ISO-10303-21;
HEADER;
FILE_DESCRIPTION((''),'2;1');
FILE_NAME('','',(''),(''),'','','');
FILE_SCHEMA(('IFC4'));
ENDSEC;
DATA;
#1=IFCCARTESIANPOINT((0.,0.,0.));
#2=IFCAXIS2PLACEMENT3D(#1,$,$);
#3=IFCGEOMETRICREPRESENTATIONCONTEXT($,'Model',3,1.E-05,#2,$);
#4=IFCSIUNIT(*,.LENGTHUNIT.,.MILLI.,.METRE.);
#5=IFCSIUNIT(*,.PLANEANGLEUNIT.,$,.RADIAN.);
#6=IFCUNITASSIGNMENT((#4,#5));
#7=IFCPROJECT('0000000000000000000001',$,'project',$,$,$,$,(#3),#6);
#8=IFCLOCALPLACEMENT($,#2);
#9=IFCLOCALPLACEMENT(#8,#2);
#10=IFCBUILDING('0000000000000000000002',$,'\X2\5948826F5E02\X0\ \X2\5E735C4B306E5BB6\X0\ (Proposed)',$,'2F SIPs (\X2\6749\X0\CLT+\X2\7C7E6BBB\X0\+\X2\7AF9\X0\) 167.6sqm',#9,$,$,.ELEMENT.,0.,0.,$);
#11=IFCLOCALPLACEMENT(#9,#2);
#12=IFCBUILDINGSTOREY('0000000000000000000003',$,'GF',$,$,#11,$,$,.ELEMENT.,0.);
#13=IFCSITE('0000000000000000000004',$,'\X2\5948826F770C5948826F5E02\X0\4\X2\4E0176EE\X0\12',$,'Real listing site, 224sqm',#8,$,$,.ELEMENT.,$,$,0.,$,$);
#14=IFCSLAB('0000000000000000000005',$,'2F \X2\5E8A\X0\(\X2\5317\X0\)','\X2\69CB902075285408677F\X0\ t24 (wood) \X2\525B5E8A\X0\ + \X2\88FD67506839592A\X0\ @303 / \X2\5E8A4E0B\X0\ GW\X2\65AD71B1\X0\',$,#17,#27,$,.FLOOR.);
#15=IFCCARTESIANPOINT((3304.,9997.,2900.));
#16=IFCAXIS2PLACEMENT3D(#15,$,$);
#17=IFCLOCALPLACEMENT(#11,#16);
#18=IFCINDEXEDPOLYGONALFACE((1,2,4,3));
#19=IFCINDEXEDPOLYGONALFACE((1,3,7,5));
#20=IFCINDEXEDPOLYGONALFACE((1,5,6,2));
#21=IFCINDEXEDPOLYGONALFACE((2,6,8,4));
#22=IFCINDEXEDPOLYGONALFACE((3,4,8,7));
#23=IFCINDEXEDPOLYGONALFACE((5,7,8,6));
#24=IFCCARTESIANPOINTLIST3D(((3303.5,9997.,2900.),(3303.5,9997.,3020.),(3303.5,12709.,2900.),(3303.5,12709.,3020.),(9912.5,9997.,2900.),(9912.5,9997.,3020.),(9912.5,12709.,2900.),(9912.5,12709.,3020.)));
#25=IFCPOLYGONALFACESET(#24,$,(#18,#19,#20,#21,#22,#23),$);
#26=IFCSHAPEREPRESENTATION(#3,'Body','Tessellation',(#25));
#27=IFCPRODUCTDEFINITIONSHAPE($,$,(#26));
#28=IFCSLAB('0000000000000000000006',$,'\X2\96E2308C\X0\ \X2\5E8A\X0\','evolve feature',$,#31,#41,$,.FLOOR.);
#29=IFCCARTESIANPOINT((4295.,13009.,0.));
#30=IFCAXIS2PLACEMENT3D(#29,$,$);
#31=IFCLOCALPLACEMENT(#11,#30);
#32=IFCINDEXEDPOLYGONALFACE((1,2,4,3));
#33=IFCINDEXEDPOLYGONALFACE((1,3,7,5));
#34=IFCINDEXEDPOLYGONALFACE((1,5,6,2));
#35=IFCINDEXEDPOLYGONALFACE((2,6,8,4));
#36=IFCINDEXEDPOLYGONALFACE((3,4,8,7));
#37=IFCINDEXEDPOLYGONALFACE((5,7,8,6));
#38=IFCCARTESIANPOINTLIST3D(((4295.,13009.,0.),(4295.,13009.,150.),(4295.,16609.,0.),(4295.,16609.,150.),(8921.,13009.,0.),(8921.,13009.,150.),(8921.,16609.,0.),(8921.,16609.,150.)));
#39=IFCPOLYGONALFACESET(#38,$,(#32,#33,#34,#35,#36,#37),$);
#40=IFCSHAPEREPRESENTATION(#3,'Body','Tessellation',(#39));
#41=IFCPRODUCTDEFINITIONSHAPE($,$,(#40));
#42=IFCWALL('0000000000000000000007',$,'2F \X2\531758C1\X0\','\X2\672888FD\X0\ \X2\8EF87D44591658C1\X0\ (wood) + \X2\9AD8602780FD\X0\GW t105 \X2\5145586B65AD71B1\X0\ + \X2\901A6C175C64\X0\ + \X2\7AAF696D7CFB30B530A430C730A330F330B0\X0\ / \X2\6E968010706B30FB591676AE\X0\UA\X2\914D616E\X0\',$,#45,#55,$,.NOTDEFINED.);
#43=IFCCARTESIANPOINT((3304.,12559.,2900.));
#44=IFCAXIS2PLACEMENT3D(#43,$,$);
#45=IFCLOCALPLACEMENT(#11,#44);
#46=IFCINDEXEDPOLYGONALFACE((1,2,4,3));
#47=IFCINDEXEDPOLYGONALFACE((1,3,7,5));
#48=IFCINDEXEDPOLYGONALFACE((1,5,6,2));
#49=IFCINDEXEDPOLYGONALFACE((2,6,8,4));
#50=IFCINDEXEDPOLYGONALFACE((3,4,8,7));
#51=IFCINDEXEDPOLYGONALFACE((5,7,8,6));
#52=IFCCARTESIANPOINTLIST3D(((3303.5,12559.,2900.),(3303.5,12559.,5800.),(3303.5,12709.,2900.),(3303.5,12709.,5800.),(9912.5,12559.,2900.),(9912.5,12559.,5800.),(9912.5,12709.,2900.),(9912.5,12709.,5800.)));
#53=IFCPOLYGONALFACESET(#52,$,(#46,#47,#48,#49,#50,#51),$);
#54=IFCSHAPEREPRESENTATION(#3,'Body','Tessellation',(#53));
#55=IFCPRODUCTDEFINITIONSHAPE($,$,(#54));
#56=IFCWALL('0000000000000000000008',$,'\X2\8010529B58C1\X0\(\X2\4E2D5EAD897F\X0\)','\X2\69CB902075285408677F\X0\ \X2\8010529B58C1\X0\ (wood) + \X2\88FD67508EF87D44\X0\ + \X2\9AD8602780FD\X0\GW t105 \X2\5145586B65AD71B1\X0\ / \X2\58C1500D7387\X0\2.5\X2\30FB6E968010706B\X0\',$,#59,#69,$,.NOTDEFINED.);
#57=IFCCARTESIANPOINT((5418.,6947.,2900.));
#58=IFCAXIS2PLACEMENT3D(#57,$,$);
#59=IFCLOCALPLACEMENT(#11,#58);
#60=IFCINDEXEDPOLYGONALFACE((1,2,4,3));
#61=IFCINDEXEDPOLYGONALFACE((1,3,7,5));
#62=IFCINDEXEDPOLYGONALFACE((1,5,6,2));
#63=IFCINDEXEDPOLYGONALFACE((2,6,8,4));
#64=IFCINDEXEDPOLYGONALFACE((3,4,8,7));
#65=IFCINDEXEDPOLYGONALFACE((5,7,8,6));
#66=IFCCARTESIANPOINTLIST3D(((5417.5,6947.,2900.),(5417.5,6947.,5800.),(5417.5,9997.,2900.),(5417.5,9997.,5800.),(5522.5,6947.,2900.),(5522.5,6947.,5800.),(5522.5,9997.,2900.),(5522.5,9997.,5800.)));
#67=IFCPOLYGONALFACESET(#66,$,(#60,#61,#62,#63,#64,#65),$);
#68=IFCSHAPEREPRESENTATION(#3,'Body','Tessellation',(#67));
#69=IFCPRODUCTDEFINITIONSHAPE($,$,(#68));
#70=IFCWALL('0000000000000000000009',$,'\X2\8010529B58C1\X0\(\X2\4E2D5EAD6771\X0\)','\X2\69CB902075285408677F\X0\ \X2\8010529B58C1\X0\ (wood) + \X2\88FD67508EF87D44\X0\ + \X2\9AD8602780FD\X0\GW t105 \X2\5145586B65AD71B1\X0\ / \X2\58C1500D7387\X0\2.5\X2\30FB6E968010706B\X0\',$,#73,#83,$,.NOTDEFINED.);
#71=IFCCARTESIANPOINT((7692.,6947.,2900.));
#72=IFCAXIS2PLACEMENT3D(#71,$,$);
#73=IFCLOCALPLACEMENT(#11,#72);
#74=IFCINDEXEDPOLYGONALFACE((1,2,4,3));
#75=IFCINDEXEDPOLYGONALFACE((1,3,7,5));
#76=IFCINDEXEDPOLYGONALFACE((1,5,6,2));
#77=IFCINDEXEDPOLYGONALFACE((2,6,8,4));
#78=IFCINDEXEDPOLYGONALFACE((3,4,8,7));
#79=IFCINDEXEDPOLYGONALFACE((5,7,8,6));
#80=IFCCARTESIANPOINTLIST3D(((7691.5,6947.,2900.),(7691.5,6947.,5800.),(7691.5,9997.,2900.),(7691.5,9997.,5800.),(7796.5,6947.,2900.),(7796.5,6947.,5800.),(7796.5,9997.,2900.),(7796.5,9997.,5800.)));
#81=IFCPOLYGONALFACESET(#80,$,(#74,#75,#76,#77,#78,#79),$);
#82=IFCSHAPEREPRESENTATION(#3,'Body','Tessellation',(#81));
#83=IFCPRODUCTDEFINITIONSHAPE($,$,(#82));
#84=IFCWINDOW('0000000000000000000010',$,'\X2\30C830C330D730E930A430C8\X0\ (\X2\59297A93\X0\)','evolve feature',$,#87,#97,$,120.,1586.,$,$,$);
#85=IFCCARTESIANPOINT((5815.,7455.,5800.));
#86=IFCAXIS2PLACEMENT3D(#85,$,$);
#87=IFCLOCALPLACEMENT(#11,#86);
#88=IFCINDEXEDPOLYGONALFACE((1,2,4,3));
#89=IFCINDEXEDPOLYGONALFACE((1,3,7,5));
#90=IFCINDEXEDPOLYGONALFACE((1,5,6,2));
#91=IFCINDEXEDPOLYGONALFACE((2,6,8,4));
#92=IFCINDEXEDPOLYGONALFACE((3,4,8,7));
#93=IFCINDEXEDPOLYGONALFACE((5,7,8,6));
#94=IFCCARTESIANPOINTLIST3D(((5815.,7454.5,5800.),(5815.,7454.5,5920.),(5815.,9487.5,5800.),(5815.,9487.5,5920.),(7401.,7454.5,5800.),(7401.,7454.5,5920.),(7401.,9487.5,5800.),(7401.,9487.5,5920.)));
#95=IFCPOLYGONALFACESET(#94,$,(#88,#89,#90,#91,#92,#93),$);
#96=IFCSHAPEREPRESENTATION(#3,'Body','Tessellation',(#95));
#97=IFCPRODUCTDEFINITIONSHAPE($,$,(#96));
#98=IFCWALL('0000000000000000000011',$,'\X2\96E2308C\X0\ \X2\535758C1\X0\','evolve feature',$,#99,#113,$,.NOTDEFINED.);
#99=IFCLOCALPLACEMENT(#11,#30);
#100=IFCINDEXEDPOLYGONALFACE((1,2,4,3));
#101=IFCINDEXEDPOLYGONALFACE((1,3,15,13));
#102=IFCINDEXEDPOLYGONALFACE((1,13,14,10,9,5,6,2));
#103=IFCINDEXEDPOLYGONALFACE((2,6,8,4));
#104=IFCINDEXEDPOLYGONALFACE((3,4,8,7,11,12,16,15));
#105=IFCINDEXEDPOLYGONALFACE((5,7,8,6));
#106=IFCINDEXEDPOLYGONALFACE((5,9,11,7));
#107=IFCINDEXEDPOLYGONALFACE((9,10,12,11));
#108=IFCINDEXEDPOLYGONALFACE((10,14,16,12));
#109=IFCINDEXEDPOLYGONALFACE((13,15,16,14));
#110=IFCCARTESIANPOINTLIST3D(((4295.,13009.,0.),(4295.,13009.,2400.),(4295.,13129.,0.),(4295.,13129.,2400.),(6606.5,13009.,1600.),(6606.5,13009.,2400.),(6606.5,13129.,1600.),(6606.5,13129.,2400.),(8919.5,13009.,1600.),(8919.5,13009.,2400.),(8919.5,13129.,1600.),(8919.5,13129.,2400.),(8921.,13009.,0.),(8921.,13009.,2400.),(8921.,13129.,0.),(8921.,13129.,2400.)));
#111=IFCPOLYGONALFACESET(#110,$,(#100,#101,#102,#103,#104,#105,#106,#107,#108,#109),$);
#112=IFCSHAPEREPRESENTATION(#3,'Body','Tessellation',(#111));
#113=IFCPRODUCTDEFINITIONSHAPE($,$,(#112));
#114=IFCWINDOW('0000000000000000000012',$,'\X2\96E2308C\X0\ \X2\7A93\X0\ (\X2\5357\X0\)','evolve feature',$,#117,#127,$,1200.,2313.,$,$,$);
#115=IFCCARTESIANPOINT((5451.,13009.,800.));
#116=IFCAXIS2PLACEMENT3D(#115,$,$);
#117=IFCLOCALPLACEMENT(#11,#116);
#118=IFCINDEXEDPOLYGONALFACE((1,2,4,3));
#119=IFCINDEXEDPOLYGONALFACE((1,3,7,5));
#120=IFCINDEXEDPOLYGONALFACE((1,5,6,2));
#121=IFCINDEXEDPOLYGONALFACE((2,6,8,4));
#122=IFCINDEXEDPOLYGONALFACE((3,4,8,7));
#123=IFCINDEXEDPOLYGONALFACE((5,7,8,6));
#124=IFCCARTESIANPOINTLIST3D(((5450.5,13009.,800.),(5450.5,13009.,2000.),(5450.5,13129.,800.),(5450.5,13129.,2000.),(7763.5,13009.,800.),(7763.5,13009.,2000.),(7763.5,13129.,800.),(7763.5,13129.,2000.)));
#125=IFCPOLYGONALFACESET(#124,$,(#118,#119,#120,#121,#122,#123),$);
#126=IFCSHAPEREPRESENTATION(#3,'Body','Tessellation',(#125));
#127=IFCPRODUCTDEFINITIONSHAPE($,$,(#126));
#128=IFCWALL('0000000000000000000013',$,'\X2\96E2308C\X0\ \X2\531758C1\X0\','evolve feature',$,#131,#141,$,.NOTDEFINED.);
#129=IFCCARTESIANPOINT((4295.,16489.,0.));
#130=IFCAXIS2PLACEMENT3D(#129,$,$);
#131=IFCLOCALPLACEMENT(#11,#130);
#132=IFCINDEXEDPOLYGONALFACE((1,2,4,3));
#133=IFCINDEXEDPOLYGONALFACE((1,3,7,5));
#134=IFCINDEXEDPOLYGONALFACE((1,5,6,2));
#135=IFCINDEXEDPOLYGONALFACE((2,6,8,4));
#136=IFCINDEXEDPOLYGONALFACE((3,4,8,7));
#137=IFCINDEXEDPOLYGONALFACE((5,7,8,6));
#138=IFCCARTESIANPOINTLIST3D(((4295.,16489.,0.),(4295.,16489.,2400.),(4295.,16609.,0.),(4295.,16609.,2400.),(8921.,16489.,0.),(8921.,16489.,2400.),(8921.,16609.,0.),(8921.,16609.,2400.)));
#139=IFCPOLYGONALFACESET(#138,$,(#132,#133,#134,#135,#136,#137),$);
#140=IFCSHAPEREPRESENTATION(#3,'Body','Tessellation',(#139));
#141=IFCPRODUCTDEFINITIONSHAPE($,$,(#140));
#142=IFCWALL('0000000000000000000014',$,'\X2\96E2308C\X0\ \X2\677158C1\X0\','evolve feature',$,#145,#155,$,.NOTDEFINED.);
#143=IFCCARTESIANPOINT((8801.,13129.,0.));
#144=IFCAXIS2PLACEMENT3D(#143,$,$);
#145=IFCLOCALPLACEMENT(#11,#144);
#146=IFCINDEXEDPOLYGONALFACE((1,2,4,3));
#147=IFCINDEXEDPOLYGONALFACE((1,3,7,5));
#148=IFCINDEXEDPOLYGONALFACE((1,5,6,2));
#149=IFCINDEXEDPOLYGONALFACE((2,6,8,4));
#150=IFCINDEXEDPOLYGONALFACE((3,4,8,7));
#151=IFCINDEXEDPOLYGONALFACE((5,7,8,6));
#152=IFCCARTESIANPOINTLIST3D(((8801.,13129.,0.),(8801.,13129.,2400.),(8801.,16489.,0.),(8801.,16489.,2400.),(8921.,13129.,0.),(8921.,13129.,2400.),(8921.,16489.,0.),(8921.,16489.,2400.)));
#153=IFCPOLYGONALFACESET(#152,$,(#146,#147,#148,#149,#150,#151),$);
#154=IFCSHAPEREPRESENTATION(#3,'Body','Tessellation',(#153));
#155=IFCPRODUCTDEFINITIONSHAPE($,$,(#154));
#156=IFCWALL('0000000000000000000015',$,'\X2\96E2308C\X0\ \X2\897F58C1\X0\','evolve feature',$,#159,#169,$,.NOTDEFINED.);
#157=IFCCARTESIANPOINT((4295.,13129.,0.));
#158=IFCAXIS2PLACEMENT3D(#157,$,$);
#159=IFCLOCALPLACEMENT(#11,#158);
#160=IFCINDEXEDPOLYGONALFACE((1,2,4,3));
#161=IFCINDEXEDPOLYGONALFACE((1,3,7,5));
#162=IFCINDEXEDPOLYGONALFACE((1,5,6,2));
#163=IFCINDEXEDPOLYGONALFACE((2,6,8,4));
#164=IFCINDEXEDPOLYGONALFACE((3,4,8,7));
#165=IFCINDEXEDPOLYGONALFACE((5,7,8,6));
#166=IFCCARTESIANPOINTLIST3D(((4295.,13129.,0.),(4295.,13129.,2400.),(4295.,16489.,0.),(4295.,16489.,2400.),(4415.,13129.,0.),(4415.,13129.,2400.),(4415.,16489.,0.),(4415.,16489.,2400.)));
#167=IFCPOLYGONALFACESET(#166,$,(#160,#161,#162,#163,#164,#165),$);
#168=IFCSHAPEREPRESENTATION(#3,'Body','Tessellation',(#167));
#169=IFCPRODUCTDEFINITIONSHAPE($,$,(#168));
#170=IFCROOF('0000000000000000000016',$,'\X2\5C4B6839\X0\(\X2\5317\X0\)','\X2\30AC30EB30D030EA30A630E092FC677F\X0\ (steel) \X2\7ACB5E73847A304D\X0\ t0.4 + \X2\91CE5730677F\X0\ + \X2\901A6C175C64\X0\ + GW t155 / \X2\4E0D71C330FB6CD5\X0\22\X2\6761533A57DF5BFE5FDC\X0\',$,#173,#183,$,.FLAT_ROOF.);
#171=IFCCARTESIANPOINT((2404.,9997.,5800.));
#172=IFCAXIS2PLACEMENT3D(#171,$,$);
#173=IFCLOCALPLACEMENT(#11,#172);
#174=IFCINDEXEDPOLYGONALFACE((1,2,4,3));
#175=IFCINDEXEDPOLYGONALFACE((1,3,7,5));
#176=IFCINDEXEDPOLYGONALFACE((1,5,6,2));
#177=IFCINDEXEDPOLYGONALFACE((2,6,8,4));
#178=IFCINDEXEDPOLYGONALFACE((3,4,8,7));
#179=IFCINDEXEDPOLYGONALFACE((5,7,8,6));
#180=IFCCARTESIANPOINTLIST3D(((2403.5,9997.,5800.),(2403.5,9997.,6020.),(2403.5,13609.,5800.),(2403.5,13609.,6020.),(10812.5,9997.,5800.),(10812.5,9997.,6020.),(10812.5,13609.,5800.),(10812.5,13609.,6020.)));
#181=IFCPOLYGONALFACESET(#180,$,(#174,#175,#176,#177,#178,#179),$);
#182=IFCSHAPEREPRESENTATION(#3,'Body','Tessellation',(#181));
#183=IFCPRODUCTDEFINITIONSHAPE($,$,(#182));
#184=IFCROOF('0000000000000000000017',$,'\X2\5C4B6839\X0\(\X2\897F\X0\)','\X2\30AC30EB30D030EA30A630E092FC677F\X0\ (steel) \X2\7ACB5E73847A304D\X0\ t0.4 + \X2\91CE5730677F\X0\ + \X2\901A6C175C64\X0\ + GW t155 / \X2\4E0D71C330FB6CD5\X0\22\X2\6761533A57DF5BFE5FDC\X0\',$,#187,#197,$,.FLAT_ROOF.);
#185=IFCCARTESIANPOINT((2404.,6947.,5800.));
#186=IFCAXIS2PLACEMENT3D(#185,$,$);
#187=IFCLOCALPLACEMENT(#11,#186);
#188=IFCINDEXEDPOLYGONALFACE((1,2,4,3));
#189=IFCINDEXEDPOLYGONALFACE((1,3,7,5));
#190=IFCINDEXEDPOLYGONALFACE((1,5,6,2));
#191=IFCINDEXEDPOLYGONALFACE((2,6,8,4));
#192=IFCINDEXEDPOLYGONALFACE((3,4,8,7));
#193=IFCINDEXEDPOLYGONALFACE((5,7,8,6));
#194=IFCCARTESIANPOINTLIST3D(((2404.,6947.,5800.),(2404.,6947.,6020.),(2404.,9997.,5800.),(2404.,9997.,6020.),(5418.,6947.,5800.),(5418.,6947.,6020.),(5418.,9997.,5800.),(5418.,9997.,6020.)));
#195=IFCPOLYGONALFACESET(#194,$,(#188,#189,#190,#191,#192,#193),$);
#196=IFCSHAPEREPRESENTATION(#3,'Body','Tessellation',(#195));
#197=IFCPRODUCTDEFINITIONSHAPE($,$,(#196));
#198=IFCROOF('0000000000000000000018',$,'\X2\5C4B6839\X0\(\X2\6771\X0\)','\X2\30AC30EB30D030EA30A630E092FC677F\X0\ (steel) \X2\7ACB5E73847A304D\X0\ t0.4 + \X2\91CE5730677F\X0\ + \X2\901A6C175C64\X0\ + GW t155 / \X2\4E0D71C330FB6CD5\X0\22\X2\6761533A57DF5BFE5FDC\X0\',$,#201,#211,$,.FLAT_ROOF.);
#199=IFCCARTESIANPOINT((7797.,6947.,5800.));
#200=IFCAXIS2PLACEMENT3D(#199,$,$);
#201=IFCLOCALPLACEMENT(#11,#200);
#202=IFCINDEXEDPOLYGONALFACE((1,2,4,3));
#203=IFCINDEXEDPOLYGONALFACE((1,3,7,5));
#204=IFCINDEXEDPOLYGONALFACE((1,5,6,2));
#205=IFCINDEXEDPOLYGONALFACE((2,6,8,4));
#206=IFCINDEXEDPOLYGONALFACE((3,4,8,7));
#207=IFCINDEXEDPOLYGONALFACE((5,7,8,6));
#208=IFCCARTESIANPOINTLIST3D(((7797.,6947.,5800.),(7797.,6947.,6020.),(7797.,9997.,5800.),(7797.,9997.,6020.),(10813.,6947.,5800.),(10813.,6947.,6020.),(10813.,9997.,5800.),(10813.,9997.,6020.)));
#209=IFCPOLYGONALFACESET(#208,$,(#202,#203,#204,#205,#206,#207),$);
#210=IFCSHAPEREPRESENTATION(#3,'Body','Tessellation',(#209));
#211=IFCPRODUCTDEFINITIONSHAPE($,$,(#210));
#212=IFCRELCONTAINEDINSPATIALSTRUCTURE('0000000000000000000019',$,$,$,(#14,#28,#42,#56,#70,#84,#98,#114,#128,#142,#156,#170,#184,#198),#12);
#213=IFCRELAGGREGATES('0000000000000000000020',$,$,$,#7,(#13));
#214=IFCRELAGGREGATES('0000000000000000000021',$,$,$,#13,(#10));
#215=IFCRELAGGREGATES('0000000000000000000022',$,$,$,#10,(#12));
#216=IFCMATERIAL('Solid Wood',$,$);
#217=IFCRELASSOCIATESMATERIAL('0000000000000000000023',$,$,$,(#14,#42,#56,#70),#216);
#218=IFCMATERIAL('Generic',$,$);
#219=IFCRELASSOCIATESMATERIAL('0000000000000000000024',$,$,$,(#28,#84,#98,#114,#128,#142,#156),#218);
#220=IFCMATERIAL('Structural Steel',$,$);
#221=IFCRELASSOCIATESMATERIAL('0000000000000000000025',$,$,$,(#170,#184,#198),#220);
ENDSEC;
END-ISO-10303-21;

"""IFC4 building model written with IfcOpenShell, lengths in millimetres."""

from ifc_helpers import new_model, si_unit, frame, frame_2d, origin, place, context, project, spatial, rectangle, extrude, material, element, fill, save


model = new_model("IFC4")

# Units and contexts
model_context = context("Model", 3, precision=1e-05, world=origin())
ifc_project = project(units=[si_unit("LENGTHUNIT", "METRE", prefix="MILLI"), si_unit("PLANEANGLEUNIT", "RADIAN")], contexts=[model_context])

# Site, building, storey
site_placement = place(None, origin())
site = spatial("IfcSite", under=ifc_project, at=site_placement, Name="奈良県奈良市4丁目12", ObjectType="Real listing site, 224sqm", CompositionType="ELEMENT", RefElevation=0.0)
building_placement = place(site_placement, origin())
building = spatial("IfcBuilding", under=site, at=building_placement, Name="奈良市 平屋の家 (Proposed)", ObjectType="2F SIPs (杉CLT+籾殻+竹) 167.6sqm", CompositionType="ELEMENT", ElevationOfRefHeight=0.0, ElevationOfTerrain=0.0)
storey_placement = place(building_placement, origin())
storey = spatial("IfcBuildingStorey", under=building, at=storey_placement, Name="GF", CompositionType="ELEMENT", Elevation=0.0)

# Slabs
ifc_material_1 = material(Name="Solid Wood")
slab_1_placement = place(storey_placement, frame((3304.0, 9997.0, 2900.0)))
element("IfcSlab", 1, at=slab_1_placement, inside=storey, material=ifc_material_1, Name="2F 床(北)", Description="構造用合板 t24 (wood) 剛床 + 製材根太 @303 / 床下 GW断熱", PredefinedType="FLOOR", context=model_context, shape_type="SweptSolid", body=[
    extrude(rectangle(XDim=6609.0, YDim=2712.0, at=frame_2d((3304.0, 1356.0))), frame((3304.0, 9997.0, 2900.0)), (0.0, 0.0, 1.0), 120.0),
])
ifc_material_2 = material(Name="Generic")
slab_2_placement = place(storey_placement, frame((4295.0, 13009.0, 0.0)))
element("IfcSlab", 2, at=slab_2_placement, inside=storey, material=ifc_material_2, Name="離れ 床", Description="evolve feature", PredefinedType="FLOOR", context=model_context, shape_type="SweptSolid", body=[
    extrude(rectangle(XDim=4626.0, YDim=3600.0, at=frame_2d((2313.0, 1800.0))), frame((4295.0, 13009.0, 0.0)), (0.0, 0.0, 1.0), 150.0),
])

# Wall
wall_1_placement = place(storey_placement, frame((3304.0, 12559.0, 2900.0)))
element("IfcWall", 3, at=wall_1_placement, inside=storey, material=ifc_material_1, Name="2F 北壁", Description="木製 軸組外壁 (wood) + 高性能GW t105 充填断熱 + 通気層 + 窯業系サイディング / 準耐火・外皮UA配慮", PredefinedType="NOTDEFINED", context=model_context, shape_type="SweptSolid", body=[
    extrude(rectangle(XDim=6609.0, YDim=150.0, at=frame_2d((3304.0, 75.0))), frame((3304.0, 12559.0, 2900.0)), (0.0, 0.0, 1.0), 2900.0),
])

# Walls
wall_2_placement = place(storey_placement, frame((5418.0, 6947.0, 2900.0)))
element("IfcWall", 4, at=wall_2_placement, inside=storey, material=ifc_material_1, Name="耐力壁(中庭西)", Description="構造用合板 耐力壁 (wood) + 製材軸組 + 高性能GW t105 充填断熱 / 壁倍率2.5・準耐火", PredefinedType="NOTDEFINED", context=model_context, shape_type="SweptSolid", body=[
    extrude(rectangle(XDim=105.0, YDim=3050.0, at=frame_2d((52.0, 1525.0))), frame((5418.0, 6947.0, 2900.0)), (0.0, 0.0, 1.0), 2900.0),
])
wall_3_placement = place(storey_placement, frame((7692.0, 6947.0, 2900.0)))
element("IfcWall", 5, at=wall_3_placement, inside=storey, material=ifc_material_1, Name="耐力壁(中庭東)", Description="構造用合板 耐力壁 (wood) + 製材軸組 + 高性能GW t105 充填断熱 / 壁倍率2.5・準耐火", PredefinedType="NOTDEFINED", context=model_context, shape_type="SweptSolid", body=[
    extrude(rectangle(XDim=105.0, YDim=3050.0, at=frame_2d((52.0, 1525.0))), frame((7692.0, 6947.0, 2900.0)), (0.0, 0.0, 1.0), 2900.0),
])

# Window
window_1_placement = place(storey_placement, frame((5815.0, 7455.0, 5800.0)))
element("IfcWindow", 6, at=window_1_placement, inside=storey, material=ifc_material_2, Name="トップライト (天窓)", Description="evolve feature", OverallHeight=120.0, OverallWidth=1586.0, context=model_context, shape_type="SweptSolid", body=[
    extrude(rectangle(XDim=1586.0, YDim=2033.0, at=frame_2d((793.0, 1016.0))), frame((5815.0, 7455.0, 5800.0)), (0.0, 0.0, 1.0), 120.0),
])

# Wall, opening, window
wall_4_placement = place(storey_placement, frame((4295.0, 13009.0, 0.0)))
wall_4 = element("IfcWall", 7, at=wall_4_placement, inside=storey, material=ifc_material_2, Name="離れ 南壁", Description="evolve feature", PredefinedType="NOTDEFINED", context=model_context, shape_type="SweptSolid", body=[
    extrude(rectangle(XDim=4626.0, YDim=120.0, at=frame_2d((2313.0, 60.0))), frame((4295.0, 13009.0, 0.0)), (0.0, 0.0, 1.0), 2400.0),
])
opening_1_placement = place(storey_placement, frame((5451.0, 13009.0, 800.0)))
opening_1 = element("IfcOpeningElement", 8, at=opening_1_placement, cuts=wall_4, PredefinedType="NOTDEFINED", context=model_context, shape_type="SweptSolid", body=[
    extrude(rectangle(XDim=2313.0, YDim=120.0, at=frame_2d((1156.0, 60.0))), frame((5451.0, 13009.0, 800.0)), (0.0, 0.0, 1.0), 1200.0),
])
window_2_placement = place(storey_placement, frame((5451.0, 13009.0, 800.0)))
window_2 = element("IfcWindow", 9, at=window_2_placement, inside=storey, material=ifc_material_2, Name="離れ 窓 (南)", Description="evolve feature", OverallHeight=1200.0, OverallWidth=2313.0, context=model_context, shape_type="SweptSolid", body=[
    extrude(rectangle(XDim=2313.0, YDim=120.0, at=frame_2d((1156.0, 60.0))), frame((5451.0, 13009.0, 800.0)), (0.0, 0.0, 1.0), 1200.0),
])
fill(opening_1, window_2)

# Walls
wall_5_placement = place(storey_placement, frame((4295.0, 16489.0, 0.0)))
element("IfcWall", 10, at=wall_5_placement, inside=storey, material=ifc_material_2, Name="離れ 北壁", Description="evolve feature", PredefinedType="NOTDEFINED", context=model_context, shape_type="SweptSolid", body=[
    extrude(rectangle(XDim=4626.0, YDim=120.0, at=frame_2d((2313.0, 60.0))), frame((4295.0, 16489.0, 0.0)), (0.0, 0.0, 1.0), 2400.0),
])
wall_6_placement = place(storey_placement, frame((8801.0, 13129.0, 0.0)))
element("IfcWall", 11, at=wall_6_placement, inside=storey, material=ifc_material_2, Name="離れ 東壁", Description="evolve feature", PredefinedType="NOTDEFINED", context=model_context, shape_type="SweptSolid", body=[
    extrude(rectangle(XDim=120.0, YDim=3360.0, at=frame_2d((60.0, 1680.0))), frame((8801.0, 13129.0, 0.0)), (0.0, 0.0, 1.0), 2400.0),
])
wall_7_placement = place(storey_placement, frame((4295.0, 13129.0, 0.0)))
element("IfcWall", 12, at=wall_7_placement, inside=storey, material=ifc_material_2, Name="離れ 西壁", Description="evolve feature", PredefinedType="NOTDEFINED", context=model_context, shape_type="SweptSolid", body=[
    extrude(rectangle(XDim=120.0, YDim=3360.0, at=frame_2d((60.0, 1680.0))), frame((4295.0, 13129.0, 0.0)), (0.0, 0.0, 1.0), 2400.0),
])

# Roofs
ifc_material_3 = material(Name="Structural Steel")
for number, where, name in (
    (13, (2404.0, 9997.0, 5800.0), "屋根(北)"),
):
    element("IfcRoof", number, at=place(storey_placement, frame(where)), inside=storey, material=ifc_material_3, Name=name, Description="ガルバリウム鋼板 (steel) 立平葺き t0.4 + 野地板 + 通気層 + GW t155 / 不燃・法22条区域対応", PredefinedType="FLAT_ROOF", context=model_context, shape_type="SweptSolid", body=[
        extrude(rectangle(XDim=8409.0, YDim=3612.0, at=frame_2d((4204.0, 1806.0))), frame((2404.0, 9997.0, 5800.0)), (0.0, 0.0, 1.0), 220.0),
    ])
roof_1_placement = place(storey_placement, frame((2404.0, 6947.0, 5800.0)))
element("IfcRoof", 14, at=roof_1_placement, inside=storey, material=ifc_material_3, Name="屋根(西)", Description="ガルバリウム鋼板 (steel) 立平葺き t0.4 + 野地板 + 通気層 + GW t155 / 不燃・法22条区域対応", PredefinedType="FLAT_ROOF", context=model_context, shape_type="SweptSolid", body=[
    extrude(rectangle(XDim=3014.0, YDim=3050.0, at=frame_2d((1507.0, 1525.0))), frame((2404.0, 6947.0, 5800.0)), (0.0, 0.0, 1.0), 220.0),
])
roof_2_placement = place(storey_placement, frame((7797.0, 6947.0, 5800.0)))
element("IfcRoof", 15, at=roof_2_placement, inside=storey, material=ifc_material_3, Name="屋根(東)", Description="ガルバリウム鋼板 (steel) 立平葺き t0.4 + 野地板 + 通気層 + GW t155 / 不燃・法22条区域対応", PredefinedType="FLAT_ROOF", context=model_context, shape_type="SweptSolid", body=[
    extrude(rectangle(XDim=3016.0, YDim=3050.0, at=frame_2d((1508.0, 1525.0))), frame((7797.0, 6947.0, 5800.0)), (0.0, 0.0, 1.0), 220.0),
])

save(model, "model.ifc")
